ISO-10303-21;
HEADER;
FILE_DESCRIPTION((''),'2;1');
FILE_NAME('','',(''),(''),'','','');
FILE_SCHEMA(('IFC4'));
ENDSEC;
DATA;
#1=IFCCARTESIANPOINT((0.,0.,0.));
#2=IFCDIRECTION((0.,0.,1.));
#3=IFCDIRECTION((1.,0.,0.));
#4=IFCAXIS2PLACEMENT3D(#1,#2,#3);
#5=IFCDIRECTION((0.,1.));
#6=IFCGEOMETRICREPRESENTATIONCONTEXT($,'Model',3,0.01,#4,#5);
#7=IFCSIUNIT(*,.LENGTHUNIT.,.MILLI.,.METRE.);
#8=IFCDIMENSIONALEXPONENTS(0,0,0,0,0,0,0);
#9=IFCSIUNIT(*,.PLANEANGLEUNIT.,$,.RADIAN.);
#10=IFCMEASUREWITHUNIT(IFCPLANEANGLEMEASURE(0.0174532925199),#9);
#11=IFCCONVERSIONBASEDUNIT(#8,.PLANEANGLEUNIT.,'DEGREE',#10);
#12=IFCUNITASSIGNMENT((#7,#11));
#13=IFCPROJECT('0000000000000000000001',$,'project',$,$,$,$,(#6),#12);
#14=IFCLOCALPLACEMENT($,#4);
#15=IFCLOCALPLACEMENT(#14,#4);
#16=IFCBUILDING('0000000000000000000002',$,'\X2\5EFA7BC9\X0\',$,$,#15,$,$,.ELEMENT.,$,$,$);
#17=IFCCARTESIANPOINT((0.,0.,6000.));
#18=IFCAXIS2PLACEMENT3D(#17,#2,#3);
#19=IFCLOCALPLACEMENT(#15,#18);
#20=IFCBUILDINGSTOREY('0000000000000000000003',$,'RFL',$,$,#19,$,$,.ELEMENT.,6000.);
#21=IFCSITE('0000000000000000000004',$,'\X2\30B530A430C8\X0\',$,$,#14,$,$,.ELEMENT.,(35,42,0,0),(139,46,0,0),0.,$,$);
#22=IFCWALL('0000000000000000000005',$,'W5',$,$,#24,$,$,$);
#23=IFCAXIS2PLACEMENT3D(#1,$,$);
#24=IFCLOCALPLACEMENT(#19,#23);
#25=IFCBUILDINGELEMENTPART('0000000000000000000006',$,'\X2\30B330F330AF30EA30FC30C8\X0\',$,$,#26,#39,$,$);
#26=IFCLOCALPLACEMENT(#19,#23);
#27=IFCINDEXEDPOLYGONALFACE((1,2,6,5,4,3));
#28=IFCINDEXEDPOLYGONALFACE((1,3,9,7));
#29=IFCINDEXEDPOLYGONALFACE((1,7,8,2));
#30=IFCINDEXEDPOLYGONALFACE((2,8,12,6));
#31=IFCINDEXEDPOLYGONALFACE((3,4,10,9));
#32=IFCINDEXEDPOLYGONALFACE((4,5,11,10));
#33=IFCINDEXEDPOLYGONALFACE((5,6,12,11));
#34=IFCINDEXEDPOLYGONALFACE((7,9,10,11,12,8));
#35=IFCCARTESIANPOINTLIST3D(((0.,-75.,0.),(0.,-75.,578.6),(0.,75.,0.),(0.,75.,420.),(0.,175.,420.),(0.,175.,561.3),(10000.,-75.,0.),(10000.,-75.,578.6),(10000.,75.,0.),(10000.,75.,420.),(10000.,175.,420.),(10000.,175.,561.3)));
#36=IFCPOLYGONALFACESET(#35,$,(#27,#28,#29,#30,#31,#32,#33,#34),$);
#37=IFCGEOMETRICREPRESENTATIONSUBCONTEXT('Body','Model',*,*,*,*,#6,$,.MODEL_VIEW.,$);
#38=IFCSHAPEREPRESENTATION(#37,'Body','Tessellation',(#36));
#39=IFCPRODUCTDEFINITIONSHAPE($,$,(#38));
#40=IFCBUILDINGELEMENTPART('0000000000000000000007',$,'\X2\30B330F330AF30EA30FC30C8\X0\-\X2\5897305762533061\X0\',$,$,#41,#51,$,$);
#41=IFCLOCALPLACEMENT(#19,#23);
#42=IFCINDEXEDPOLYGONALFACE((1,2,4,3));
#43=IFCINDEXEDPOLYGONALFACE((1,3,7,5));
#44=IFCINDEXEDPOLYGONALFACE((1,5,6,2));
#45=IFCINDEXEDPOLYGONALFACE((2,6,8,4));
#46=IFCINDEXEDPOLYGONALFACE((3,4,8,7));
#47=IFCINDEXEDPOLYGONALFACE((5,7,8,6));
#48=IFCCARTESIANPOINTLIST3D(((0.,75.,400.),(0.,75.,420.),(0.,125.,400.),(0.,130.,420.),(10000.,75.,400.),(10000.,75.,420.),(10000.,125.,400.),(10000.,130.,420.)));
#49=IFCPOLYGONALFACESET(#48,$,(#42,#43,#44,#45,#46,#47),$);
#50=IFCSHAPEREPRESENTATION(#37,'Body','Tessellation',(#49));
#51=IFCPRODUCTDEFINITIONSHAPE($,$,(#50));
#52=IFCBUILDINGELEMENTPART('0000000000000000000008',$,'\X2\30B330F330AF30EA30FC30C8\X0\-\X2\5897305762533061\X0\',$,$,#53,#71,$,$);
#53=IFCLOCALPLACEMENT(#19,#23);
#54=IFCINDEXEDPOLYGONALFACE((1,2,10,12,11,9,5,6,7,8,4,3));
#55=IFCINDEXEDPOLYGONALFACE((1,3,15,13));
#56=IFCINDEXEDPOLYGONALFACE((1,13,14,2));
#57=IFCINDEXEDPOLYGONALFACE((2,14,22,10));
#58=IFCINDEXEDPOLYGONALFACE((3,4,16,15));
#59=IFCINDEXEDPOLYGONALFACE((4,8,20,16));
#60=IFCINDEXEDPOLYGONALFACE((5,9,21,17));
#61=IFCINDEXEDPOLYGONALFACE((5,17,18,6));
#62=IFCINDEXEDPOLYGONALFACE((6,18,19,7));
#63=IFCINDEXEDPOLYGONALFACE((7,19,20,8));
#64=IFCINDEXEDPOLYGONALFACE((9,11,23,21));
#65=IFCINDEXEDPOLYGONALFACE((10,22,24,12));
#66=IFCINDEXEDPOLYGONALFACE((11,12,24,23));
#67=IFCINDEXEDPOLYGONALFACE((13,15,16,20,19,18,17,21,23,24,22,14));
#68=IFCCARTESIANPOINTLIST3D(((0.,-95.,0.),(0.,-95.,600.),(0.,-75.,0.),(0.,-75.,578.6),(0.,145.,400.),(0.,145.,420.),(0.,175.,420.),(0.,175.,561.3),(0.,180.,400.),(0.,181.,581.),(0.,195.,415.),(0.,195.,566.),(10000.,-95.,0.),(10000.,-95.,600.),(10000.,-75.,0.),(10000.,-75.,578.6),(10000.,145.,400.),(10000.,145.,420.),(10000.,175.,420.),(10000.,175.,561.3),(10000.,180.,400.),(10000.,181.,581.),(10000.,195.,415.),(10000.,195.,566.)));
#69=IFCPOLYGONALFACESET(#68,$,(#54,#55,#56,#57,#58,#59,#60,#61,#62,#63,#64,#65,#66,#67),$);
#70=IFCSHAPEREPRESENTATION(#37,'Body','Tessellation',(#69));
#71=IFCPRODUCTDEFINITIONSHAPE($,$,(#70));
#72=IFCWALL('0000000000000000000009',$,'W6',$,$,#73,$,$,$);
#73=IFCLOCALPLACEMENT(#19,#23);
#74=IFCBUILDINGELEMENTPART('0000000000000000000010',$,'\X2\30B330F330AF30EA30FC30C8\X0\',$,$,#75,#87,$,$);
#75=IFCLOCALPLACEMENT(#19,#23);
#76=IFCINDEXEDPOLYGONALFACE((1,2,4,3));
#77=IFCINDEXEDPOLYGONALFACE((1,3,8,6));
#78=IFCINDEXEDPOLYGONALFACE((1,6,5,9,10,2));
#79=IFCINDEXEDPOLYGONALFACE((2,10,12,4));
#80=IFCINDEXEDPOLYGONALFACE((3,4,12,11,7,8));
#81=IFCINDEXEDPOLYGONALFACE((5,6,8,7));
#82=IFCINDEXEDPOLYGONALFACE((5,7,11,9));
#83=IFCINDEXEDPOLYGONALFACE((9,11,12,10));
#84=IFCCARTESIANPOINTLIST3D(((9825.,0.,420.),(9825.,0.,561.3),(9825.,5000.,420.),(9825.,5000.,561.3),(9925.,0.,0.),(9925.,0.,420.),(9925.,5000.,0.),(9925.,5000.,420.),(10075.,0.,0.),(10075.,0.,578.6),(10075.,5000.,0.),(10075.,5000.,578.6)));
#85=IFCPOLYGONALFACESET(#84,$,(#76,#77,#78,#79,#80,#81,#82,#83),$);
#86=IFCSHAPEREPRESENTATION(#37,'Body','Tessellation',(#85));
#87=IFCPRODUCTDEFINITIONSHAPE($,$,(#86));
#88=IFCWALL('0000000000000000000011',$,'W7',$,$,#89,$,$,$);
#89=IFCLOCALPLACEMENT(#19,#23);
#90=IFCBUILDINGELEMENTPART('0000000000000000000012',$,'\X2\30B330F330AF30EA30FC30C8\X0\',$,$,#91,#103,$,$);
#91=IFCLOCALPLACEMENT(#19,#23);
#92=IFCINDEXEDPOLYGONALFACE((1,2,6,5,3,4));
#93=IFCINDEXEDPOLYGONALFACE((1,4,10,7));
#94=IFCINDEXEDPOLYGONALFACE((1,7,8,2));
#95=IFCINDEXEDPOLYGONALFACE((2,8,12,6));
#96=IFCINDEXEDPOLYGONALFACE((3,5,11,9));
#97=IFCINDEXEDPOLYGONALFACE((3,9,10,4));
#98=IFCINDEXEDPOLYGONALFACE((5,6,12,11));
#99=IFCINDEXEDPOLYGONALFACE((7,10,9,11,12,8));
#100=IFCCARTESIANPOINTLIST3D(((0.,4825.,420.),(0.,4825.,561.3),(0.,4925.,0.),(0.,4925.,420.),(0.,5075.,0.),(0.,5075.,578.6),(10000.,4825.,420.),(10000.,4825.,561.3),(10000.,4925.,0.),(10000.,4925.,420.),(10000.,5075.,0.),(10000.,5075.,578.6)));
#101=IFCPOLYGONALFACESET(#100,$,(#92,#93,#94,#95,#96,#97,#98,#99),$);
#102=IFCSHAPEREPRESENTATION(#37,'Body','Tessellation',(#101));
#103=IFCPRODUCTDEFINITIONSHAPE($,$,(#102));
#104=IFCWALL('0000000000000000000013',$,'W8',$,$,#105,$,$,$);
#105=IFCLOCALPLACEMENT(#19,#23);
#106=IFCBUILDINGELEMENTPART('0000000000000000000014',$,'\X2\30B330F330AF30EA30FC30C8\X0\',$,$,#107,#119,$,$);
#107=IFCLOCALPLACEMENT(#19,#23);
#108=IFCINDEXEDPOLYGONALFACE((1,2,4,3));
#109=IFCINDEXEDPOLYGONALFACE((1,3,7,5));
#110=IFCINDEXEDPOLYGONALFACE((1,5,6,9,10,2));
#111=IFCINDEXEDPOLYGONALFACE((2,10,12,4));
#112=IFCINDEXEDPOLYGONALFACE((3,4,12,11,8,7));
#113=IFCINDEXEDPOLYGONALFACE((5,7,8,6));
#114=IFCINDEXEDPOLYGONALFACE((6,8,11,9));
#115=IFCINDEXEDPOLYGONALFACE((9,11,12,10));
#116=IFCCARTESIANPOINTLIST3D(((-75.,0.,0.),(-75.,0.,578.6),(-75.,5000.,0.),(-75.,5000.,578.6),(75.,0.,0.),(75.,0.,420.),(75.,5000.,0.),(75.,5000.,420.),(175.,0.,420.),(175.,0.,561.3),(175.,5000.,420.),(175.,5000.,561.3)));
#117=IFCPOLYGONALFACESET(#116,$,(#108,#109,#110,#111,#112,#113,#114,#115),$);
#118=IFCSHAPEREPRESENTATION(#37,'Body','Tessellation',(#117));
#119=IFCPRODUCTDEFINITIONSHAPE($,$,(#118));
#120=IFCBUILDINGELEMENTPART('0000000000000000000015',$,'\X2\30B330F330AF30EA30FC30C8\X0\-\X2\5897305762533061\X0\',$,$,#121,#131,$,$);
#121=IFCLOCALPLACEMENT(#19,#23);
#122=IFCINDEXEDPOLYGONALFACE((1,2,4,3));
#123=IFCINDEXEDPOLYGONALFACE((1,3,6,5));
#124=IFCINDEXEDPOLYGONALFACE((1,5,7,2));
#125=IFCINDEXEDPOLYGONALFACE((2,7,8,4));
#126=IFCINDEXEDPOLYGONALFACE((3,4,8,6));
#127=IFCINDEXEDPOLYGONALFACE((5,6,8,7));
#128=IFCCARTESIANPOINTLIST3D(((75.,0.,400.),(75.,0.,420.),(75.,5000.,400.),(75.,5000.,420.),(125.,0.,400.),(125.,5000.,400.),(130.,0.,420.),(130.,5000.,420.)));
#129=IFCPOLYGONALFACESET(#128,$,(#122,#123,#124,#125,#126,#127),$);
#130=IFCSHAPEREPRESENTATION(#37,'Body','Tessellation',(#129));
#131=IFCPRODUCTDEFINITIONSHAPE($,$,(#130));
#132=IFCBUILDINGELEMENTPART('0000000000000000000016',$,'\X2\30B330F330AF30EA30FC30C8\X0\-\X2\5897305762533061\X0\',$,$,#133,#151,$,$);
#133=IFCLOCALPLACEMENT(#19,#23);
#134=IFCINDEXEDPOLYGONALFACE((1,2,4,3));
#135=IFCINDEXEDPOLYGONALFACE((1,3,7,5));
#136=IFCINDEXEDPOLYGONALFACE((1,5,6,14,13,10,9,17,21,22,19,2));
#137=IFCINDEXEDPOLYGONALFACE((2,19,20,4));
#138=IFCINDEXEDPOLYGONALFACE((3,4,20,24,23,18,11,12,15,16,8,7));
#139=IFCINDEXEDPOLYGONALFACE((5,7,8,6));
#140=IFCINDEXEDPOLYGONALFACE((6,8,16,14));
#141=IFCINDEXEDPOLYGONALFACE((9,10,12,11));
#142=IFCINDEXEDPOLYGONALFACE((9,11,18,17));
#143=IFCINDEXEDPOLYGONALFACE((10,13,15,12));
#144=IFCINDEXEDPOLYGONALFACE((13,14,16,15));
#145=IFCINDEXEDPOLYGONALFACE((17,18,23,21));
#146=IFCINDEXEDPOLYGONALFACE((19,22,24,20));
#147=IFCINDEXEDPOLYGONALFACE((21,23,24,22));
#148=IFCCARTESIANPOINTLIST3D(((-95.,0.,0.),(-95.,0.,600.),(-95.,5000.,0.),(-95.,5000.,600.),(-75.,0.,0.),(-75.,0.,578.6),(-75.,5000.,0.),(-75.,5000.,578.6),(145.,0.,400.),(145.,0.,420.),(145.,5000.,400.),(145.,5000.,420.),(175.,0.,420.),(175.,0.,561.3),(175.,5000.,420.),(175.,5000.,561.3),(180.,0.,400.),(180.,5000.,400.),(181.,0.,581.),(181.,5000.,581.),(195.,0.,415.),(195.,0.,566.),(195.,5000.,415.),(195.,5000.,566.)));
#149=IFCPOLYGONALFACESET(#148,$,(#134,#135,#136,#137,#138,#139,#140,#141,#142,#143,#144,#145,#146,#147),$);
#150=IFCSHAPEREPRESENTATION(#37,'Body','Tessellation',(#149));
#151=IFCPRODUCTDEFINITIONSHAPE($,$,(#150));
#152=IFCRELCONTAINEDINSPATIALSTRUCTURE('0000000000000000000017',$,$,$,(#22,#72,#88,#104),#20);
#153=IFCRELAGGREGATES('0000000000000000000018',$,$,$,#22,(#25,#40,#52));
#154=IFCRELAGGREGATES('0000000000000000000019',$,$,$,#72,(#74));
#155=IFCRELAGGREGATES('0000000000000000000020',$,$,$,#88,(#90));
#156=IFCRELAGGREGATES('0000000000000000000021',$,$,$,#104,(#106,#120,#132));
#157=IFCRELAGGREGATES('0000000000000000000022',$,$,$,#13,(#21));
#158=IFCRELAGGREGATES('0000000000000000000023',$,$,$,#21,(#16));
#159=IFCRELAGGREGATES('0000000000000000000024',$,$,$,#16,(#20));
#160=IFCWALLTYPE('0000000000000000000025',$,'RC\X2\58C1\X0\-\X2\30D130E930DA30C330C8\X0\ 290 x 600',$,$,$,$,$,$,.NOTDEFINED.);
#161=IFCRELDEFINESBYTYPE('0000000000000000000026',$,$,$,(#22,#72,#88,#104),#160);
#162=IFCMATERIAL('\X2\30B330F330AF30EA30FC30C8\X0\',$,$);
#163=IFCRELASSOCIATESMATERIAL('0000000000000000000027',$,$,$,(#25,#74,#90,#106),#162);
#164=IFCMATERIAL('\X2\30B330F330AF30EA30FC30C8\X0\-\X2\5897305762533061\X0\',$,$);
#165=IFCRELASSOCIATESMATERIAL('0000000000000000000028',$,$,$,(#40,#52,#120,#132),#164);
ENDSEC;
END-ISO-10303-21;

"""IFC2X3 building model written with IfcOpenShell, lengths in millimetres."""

from ifc_helpers import new_model, entity, si_unit, converted_unit, direction, frame, origin_with_axes, place, context, subcontext, project, spatial, polyline, outline, extrude, material, type_object, element, aggregate, save


model = new_model("IFC2X3")

# Units and contexts
model_context = context("Model", 3, precision=0.01, world=origin_with_axes(), true_north=direction((0.0, 1.0)))
body_context = subcontext(model_context, "Body", "Model", "MODEL_VIEW")
ifc_project = project(units=[si_unit("LENGTHUNIT", "METRE", prefix="MILLI"), converted_unit("PLANEANGLEUNIT", "DEGREE", entity("IfcPlaneAngleMeasure", 0.0174532925199), si_unit("PLANEANGLEUNIT", "RADIAN"), dimensions=[0, 0, 0, 0, 0, 0, 0])], contexts=[model_context])

# Site, building, storey
site_placement = place(None, origin_with_axes())
site = spatial("IfcSite", under=ifc_project, at=site_placement, Name="サイト", CompositionType="ELEMENT", RefLatitude=(35, 42, 0, 0), RefLongitude=(139, 46, 0, 0), RefElevation=0.0)
building_placement = place(site_placement, origin_with_axes())
building = spatial("IfcBuilding", under=site, at=building_placement, Name="建築", CompositionType="ELEMENT")
storey_placement = place(building_placement, frame((0.0, 0.0, 6000.0), z_axis=(0.0, 0.0, 1.0), x_axis=(1.0, 0.0, 0.0)))
storey = spatial("IfcBuildingStorey", under=building, at=storey_placement, Name="RFL", CompositionType="ELEMENT", Elevation=6000.0)

# Shared definitions
ifc_material_1 = material(Name="コンクリート")

# Walls, building element parts
wall_type = type_object("IfcWallType", Name="RC壁-パラペット 290 x 600", PredefinedType="NOTDEFINED")
wall_1_placement = place(storey_placement, origin_with_axes())
wall_1 = element("IfcWall", 1, at=wall_1_placement, inside=storey, type_object=wall_type, Name="W5")
building_element_part_1_placement = place(wall_1_placement, origin_with_axes())
building_element_part_1 = element("IfcBuildingElementPart", 2, at=building_element_part_1_placement, material=ifc_material_1, Name="コンクリート", context=body_context, shape_type="SweptSolid", body=[
    extrude(outline(polyline([(75.0, 0.0), (75.0, 578.6), (-175.0, 561.3), (-175.0, 420.0), (-75.0, 420.0), (-75.0, 0.0), (75.0, 0.0)])), frame((0.0, 0.0, 0.0), z_axis=(-1.0, 0.0, 0.0), x_axis=(0.0, -1.0, 0.0)), (0.0, 0.0, -1.0), 10000.0),
])
ifc_material_2 = material(Name="コンクリート-増し打ち")
building_element_part_2_placement = place(wall_1_placement, origin_with_axes())
building_element_part_2 = element("IfcBuildingElementPart", 3, at=building_element_part_2_placement, material=ifc_material_2, Name="コンクリート-増し打ち", context=body_context, shape_type="SweptSolid", body=[
    extrude(outline(polyline([(-130.0, 420.0), (-125.0, 400.0), (-75.0, 400.0), (-75.0, 420.0), (-130.0, 420.0)])), frame((0.0, 0.0, 0.0), z_axis=(-1.0, 0.0, 0.0), x_axis=(0.0, -1.0, 0.0)), (0.0, 0.0, -1.0), 10000.0),
])
building_element_part_3_placement = place(wall_1_placement, origin_with_axes())
building_element_part_3 = element("IfcBuildingElementPart", 4, at=building_element_part_3_placement, material=ifc_material_2, Name="コンクリート-増し打ち", context=body_context, shape_type="SweptSolid", body=[
    extrude(outline(polyline([(-195.0, 415.0), (-180.0, 400.0), (-145.0, 400.0), (-145.0, 420.0), (-175.0, 420.0), (-175.0, 561.3), (75.0, 578.6), (75.0, 0.0), (95.0, 0.0), (95.0, 600.0), (-181.0, 581.0), (-195.0, 566.0), (-195.0, 415.0)])), frame((0.0, 0.0, 0.0), z_axis=(-1.0, 0.0, 0.0), x_axis=(0.0, -1.0, 0.0)), (0.0, 0.0, -1.0), 10000.0),
])
aggregate(wall_1, [building_element_part_1, building_element_part_2, building_element_part_3])
wall_2_placement = place(storey_placement, frame((10000.0, 0.0, 0.0), z_axis=(0.0, 0.0, 1.0), x_axis=(0.0, 1.0, 0.0)))
wall_2 = element("IfcWall", 5, at=wall_2_placement, inside=storey, type_object=wall_type, Name="W6")
building_element_part_4_placement = place(wall_2_placement, origin_with_axes())
building_element_part_4 = element("IfcBuildingElementPart", 6, at=building_element_part_4_placement, material=ifc_material_1, Name="コンクリート", context=body_context, shape_type="SweptSolid", body=[
    extrude(outline(polyline([(75.0, 0.0), (75.0, 578.6), (-175.0, 561.3), (-175.0, 420.0), (-75.0, 420.0), (-75.0, 0.0), (75.0, 0.0)])), frame((0.0, 0.0, 0.0), z_axis=(-1.0, 0.0, 0.0), x_axis=(0.0, -1.0, 0.0)), (0.0, 0.0, -1.0), 5000.0),
])
aggregate(wall_2, [building_element_part_4])
wall_3_placement = place(storey_placement, frame((10000.0, 5000.0, 0.0), z_axis=(0.0, 0.0, 1.0), x_axis=(-1.0, 0.0, 0.0)))
wall_3 = element("IfcWall", 7, at=wall_3_placement, inside=storey, type_object=wall_type, Name="W7")
building_element_part_5_placement = place(wall_3_placement, origin_with_axes())
building_element_part_5 = element("IfcBuildingElementPart", 8, at=building_element_part_5_placement, material=ifc_material_1, Name="コンクリート", context=body_context, shape_type="SweptSolid", body=[
    extrude(outline(polyline([(75.0, 0.0), (75.0, 578.6), (-175.0, 561.3), (-175.0, 420.0), (-75.0, 420.0), (-75.0, 0.0), (75.0, 0.0)])), frame((0.0, 0.0, 0.0), z_axis=(-1.0, 0.0, 0.0), x_axis=(0.0, -1.0, 0.0)), (0.0, 0.0, -1.0), 10000.0),
])
aggregate(wall_3, [building_element_part_5])
wall_4_placement = place(storey_placement, frame((0.0, 5000.0, 0.0), z_axis=(0.0, 0.0, 1.0), x_axis=(0.0, -1.0, 0.0)))
wall_4 = element("IfcWall", 9, at=wall_4_placement, inside=storey, type_object=wall_type, Name="W8")
building_element_part_6_placement = place(wall_4_placement, origin_with_axes())
building_element_part_6 = element("IfcBuildingElementPart", 10, at=building_element_part_6_placement, material=ifc_material_1, Name="コンクリート", context=body_context, shape_type="SweptSolid", body=[
    extrude(outline(polyline([(75.0, 0.0), (75.0, 578.6), (-175.0, 561.3), (-175.0, 420.0), (-75.0, 420.0), (-75.0, 0.0), (75.0, 0.0)])), frame((0.0, 0.0, 0.0), z_axis=(-1.0, 0.0, 0.0), x_axis=(0.0, -1.0, 0.0)), (0.0, 0.0, -1.0), 5000.0),
])
building_element_part_7_placement = place(wall_4_placement, origin_with_axes())
building_element_part_7 = element("IfcBuildingElementPart", 11, at=building_element_part_7_placement, material=ifc_material_2, Name="コンクリート-増し打ち", context=body_context, shape_type="SweptSolid", body=[
    extrude(outline(polyline([(-130.0, 420.0), (-125.0, 400.0), (-75.0, 400.0), (-75.0, 420.0), (-130.0, 420.0)])), frame((0.0, 0.0, 0.0), z_axis=(-1.0, 0.0, 0.0), x_axis=(0.0, -1.0, 0.0)), (0.0, 0.0, -1.0), 5000.0),
])
building_element_part_8_placement = place(wall_4_placement, origin_with_axes())
building_element_part_8 = element("IfcBuildingElementPart", 12, at=building_element_part_8_placement, material=ifc_material_2, Name="コンクリート-増し打ち", context=body_context, shape_type="SweptSolid", body=[
    extrude(outline(polyline([(-195.0, 415.0), (-180.0, 400.0), (-145.0, 400.0), (-145.0, 420.0), (-175.0, 420.0), (-175.0, 561.3), (75.0, 578.6), (75.0, 0.0), (95.0, 0.0), (95.0, 600.0), (-181.0, 581.0), (-195.0, 566.0), (-195.0, 415.0)])), frame((0.0, 0.0, 0.0), z_axis=(-1.0, 0.0, 0.0), x_axis=(0.0, -1.0, 0.0)), (0.0, 0.0, -1.0), 5000.0),
])
aggregate(wall_4, [building_element_part_6, building_element_part_7, building_element_part_8])

save(model, "model.ifc")
